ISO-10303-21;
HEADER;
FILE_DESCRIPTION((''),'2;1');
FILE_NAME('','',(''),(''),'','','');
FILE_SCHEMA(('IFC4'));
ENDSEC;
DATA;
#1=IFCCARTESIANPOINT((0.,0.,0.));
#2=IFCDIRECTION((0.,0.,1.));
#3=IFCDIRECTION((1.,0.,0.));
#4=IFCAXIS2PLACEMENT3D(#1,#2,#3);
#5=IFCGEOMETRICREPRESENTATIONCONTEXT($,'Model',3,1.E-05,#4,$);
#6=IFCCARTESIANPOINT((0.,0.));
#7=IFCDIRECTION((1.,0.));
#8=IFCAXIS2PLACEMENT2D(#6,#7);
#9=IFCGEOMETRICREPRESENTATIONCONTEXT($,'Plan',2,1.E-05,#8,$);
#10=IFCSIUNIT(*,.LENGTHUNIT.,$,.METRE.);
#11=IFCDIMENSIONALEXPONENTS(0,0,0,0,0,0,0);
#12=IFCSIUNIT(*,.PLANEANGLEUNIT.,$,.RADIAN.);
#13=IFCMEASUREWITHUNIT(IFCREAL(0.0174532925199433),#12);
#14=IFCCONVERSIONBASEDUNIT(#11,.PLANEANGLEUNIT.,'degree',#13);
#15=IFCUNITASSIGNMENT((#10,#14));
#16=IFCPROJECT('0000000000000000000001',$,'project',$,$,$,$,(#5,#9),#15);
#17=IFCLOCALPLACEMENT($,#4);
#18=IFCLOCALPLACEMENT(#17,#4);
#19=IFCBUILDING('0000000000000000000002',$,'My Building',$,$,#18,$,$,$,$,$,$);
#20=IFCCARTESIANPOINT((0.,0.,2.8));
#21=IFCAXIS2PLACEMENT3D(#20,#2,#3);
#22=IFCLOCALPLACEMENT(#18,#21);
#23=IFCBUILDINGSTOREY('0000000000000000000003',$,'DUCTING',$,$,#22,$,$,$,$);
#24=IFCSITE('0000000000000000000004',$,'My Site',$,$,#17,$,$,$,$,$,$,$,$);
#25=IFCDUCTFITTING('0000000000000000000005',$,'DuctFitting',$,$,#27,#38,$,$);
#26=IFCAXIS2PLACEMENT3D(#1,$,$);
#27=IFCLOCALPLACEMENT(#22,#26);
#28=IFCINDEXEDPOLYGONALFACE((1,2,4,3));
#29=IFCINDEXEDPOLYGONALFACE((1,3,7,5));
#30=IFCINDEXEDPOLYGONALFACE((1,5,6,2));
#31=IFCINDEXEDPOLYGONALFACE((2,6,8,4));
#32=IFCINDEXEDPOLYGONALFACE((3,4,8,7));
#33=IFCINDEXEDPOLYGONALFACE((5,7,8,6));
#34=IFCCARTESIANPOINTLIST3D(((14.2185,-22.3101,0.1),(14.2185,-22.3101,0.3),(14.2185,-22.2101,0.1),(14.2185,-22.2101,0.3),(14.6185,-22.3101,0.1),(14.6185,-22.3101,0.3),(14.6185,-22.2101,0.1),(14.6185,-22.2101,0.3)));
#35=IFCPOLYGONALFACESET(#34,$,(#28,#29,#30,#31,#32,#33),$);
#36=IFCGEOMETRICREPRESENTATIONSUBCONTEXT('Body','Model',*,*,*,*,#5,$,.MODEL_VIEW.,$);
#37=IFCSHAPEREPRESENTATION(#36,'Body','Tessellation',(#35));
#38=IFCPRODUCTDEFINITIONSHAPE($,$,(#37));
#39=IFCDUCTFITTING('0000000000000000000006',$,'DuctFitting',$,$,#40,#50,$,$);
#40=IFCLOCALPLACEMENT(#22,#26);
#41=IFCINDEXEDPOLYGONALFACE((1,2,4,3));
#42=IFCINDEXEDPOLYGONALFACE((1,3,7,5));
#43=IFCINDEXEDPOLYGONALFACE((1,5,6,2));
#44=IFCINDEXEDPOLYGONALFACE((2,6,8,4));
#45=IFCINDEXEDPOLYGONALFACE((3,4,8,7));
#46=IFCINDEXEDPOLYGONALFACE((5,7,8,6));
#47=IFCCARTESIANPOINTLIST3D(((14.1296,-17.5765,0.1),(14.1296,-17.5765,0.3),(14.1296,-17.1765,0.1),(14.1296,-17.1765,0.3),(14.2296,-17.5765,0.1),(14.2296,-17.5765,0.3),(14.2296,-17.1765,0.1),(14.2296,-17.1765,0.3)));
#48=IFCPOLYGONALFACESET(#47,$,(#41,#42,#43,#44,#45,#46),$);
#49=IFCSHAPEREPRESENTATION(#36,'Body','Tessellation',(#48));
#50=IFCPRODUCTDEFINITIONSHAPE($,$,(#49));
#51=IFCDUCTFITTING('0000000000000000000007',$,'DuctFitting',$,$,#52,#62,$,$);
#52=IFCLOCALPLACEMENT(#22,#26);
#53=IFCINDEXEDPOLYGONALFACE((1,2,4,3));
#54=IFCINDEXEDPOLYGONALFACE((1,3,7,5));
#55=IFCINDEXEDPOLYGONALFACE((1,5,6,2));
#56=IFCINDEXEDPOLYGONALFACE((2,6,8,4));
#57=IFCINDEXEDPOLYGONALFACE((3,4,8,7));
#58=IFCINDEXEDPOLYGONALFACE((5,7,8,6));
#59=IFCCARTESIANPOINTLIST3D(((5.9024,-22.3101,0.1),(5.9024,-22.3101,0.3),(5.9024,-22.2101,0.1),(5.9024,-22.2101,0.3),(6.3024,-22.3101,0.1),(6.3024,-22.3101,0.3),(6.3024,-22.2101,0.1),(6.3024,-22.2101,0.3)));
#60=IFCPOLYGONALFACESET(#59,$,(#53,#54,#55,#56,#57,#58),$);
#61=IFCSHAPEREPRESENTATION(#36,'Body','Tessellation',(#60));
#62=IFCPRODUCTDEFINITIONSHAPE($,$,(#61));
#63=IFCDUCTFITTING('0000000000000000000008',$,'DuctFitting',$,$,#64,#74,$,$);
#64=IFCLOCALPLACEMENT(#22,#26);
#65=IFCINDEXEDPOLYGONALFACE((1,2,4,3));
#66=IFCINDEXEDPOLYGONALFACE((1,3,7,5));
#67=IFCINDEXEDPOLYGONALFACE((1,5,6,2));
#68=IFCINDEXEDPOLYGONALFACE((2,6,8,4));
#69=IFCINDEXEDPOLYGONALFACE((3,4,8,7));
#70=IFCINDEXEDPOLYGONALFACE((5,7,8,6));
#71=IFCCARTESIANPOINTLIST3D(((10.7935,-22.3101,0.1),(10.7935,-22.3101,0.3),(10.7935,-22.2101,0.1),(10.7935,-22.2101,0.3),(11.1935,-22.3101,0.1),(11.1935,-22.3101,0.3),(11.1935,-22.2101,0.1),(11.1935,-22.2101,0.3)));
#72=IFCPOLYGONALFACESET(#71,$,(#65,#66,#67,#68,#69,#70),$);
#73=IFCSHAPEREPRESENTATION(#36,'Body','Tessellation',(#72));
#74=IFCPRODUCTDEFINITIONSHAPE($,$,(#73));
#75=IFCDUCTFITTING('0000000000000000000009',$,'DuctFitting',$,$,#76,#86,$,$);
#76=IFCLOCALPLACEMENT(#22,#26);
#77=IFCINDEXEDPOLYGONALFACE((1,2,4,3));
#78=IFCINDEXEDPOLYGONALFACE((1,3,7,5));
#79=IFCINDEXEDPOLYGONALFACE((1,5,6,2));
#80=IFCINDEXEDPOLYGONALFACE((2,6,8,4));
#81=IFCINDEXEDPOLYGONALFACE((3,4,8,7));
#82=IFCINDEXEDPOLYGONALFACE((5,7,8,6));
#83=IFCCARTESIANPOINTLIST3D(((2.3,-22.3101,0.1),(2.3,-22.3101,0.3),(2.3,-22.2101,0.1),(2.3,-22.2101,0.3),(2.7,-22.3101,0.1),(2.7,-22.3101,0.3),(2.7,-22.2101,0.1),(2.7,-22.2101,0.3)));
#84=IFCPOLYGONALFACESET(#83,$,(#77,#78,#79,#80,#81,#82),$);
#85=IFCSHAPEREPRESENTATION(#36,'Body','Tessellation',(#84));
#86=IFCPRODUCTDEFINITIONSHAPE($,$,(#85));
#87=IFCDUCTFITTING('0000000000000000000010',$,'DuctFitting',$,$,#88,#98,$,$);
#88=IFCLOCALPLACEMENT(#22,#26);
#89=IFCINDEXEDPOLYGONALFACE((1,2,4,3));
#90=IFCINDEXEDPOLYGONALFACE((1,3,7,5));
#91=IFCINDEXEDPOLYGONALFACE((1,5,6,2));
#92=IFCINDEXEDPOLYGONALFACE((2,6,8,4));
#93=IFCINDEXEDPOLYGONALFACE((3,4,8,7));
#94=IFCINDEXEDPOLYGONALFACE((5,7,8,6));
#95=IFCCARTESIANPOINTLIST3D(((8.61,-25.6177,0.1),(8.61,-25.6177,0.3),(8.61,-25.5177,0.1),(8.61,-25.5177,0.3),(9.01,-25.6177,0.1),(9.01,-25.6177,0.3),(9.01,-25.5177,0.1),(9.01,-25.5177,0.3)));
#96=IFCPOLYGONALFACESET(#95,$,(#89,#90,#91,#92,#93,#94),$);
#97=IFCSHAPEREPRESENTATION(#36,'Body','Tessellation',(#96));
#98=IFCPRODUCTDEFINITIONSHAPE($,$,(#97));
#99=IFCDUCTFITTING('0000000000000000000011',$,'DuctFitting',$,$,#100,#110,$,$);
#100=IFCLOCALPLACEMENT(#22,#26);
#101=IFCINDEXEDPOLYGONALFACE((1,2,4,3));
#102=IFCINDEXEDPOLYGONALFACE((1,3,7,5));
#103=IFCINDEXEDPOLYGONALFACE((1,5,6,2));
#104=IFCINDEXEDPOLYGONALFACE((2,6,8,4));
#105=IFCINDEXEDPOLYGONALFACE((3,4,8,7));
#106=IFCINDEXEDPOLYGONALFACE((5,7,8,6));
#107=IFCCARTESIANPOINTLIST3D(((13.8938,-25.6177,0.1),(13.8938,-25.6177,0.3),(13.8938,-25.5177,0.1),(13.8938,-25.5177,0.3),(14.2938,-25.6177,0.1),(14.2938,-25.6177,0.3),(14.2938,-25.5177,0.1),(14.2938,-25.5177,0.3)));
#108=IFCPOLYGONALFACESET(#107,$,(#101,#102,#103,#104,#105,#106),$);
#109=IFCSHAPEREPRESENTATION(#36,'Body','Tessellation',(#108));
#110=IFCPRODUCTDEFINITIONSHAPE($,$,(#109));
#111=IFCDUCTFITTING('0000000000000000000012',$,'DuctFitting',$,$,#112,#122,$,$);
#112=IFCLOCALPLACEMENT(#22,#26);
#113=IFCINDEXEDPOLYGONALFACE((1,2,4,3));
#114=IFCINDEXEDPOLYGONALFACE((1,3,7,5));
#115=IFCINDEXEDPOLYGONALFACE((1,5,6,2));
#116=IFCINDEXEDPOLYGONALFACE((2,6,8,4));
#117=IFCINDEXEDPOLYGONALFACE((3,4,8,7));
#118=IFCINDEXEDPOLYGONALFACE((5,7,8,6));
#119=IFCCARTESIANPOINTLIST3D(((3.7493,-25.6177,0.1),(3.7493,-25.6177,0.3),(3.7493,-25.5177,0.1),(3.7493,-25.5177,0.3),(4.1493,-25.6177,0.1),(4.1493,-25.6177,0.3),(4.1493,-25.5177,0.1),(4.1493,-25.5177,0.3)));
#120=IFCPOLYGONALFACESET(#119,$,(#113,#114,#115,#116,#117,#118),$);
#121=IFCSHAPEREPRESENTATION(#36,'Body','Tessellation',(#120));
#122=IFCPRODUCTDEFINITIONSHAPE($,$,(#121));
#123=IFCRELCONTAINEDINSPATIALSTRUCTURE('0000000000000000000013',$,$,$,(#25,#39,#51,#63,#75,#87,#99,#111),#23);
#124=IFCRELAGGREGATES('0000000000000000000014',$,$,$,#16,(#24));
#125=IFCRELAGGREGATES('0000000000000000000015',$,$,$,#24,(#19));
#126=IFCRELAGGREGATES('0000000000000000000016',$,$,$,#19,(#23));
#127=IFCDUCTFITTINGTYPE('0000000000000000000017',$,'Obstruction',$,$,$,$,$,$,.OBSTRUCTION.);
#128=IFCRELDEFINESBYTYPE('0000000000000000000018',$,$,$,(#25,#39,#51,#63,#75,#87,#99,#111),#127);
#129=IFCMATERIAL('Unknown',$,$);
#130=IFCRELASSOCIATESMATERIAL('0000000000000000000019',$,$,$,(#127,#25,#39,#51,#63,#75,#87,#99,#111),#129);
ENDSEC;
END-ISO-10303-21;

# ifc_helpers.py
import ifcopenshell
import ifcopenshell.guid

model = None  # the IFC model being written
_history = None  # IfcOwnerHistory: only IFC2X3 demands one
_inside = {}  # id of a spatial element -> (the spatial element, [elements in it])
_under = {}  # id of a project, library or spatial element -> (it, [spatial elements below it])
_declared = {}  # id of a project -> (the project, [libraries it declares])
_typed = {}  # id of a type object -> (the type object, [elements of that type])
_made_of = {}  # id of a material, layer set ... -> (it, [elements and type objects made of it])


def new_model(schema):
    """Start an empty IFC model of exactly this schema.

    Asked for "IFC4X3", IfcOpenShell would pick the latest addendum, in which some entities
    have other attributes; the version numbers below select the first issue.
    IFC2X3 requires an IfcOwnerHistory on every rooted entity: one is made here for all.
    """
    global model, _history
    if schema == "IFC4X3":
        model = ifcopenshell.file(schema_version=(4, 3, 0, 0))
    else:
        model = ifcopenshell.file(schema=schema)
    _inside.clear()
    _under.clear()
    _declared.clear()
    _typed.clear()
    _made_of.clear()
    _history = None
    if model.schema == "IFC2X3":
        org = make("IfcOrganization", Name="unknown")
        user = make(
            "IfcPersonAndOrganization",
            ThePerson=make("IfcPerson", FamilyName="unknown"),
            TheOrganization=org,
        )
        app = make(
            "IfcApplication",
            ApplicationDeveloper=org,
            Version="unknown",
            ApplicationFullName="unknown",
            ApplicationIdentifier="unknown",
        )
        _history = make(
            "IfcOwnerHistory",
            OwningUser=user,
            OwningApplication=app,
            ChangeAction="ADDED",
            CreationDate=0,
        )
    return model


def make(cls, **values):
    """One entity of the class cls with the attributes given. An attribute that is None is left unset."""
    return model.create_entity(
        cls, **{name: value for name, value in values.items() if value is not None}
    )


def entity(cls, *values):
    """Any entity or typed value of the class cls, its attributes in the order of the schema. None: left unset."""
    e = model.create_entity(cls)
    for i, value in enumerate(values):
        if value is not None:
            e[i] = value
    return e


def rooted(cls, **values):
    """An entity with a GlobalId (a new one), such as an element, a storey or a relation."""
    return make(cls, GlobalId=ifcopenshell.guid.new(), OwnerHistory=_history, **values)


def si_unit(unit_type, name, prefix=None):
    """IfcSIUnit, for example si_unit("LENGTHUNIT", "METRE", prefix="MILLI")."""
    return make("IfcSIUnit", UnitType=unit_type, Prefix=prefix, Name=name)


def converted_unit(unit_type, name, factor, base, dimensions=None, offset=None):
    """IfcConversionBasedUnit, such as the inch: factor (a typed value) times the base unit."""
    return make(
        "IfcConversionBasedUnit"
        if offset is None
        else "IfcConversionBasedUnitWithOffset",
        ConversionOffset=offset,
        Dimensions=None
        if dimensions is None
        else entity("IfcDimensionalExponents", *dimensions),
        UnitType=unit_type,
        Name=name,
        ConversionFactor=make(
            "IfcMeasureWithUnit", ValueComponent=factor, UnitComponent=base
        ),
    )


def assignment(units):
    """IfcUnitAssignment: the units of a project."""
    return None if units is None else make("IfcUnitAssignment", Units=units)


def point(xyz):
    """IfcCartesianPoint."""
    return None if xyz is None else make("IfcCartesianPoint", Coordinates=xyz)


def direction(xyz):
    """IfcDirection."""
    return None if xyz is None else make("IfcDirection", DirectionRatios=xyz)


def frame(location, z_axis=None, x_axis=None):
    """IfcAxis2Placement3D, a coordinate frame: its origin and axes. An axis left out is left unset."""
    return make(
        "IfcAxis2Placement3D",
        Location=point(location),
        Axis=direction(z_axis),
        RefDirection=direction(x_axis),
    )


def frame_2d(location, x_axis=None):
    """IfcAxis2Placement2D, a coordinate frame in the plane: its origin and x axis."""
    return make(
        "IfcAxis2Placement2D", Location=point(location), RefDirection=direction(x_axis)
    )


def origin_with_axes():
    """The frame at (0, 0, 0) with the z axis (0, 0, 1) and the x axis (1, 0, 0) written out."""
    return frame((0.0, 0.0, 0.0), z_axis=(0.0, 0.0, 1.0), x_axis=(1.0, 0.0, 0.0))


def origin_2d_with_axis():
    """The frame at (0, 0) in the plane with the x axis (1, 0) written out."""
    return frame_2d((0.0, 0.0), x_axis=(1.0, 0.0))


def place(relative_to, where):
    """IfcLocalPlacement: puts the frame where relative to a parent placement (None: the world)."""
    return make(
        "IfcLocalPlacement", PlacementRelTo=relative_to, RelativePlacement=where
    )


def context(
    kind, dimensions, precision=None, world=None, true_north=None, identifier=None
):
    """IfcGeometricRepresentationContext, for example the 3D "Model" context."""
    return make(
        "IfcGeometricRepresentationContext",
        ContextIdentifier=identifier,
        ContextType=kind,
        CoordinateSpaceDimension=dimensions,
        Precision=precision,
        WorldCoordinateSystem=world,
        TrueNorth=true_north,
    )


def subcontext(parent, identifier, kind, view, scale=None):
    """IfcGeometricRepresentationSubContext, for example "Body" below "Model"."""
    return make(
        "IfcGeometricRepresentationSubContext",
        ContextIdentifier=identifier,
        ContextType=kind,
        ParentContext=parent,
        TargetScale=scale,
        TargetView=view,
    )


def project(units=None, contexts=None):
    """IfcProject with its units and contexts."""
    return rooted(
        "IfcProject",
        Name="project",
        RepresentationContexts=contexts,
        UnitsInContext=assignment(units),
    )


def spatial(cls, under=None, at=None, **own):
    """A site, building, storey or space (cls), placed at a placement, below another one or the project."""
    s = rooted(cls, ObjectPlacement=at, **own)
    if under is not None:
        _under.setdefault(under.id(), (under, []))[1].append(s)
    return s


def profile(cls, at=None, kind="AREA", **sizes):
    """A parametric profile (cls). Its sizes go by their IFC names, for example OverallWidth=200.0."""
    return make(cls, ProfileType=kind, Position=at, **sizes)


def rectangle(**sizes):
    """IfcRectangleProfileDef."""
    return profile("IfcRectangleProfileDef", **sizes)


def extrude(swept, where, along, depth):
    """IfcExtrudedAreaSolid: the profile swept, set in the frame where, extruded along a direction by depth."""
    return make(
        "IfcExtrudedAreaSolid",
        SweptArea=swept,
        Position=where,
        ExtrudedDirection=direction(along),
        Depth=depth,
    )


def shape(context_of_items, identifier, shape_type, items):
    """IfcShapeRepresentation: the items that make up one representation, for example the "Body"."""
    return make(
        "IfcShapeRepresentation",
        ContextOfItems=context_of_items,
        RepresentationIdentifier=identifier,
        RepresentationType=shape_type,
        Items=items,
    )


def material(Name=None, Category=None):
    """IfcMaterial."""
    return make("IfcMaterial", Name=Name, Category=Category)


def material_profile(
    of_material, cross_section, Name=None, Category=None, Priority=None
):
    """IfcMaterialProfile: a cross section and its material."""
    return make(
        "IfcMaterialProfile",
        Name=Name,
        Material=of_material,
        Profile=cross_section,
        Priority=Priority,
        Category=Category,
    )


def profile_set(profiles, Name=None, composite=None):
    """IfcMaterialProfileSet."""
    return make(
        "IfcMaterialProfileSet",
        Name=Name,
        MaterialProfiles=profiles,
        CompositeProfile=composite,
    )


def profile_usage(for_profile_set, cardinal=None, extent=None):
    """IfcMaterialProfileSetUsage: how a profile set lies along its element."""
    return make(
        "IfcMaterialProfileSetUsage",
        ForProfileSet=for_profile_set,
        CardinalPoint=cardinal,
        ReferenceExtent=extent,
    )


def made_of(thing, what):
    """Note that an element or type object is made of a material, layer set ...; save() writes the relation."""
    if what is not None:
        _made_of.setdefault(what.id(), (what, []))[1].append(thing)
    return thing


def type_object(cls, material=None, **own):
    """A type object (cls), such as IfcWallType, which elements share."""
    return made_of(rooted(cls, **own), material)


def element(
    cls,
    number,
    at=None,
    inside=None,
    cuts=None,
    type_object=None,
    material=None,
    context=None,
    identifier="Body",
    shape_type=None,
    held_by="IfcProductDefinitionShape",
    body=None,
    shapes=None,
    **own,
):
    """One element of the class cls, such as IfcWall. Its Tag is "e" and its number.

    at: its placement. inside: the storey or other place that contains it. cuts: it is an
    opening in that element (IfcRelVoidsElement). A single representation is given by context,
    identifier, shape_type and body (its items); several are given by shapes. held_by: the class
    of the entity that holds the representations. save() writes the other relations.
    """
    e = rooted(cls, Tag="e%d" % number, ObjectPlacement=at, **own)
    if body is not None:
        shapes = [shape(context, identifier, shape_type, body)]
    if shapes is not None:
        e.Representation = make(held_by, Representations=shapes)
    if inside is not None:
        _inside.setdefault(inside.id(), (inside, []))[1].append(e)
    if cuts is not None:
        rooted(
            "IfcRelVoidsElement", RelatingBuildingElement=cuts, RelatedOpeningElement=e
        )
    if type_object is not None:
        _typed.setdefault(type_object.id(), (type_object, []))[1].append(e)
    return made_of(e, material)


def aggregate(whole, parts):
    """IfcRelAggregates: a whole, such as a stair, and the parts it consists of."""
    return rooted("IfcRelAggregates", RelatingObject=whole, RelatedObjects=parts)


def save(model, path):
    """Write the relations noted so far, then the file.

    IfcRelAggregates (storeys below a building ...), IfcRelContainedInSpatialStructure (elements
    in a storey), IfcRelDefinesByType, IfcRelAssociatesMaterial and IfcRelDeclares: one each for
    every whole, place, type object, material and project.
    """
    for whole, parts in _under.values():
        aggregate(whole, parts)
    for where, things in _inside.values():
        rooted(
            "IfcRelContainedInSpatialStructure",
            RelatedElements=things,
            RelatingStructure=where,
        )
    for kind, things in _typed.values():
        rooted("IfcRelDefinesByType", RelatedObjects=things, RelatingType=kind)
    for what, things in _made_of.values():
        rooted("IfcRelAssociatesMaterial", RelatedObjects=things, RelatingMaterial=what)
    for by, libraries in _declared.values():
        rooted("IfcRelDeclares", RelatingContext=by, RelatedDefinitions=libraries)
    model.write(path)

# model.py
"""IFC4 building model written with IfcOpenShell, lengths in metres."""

from ifc_helpers import new_model, entity, si_unit, converted_unit, frame, origin_with_axes, origin_2d_with_axis, place, context, subcontext, project, spatial, rectangle, extrude, material, material_profile, profile_set, profile_usage, type_object, element, save


model = new_model("IFC4")

# Units and contexts
model_context = context("Model", 3, precision=1e-05, world=origin_with_axes())
plan_context = context("Plan", 2, precision=1e-05, world=origin_2d_with_axis())
body_context = subcontext(model_context, "Body", "Model", "MODEL_VIEW")
ifc_project = project(units=[si_unit("LENGTHUNIT", "METRE"), converted_unit("PLANEANGLEUNIT", "degree", entity("IfcReal", 0.0174532925199433), si_unit("PLANEANGLEUNIT", "RADIAN"), dimensions=[0, 0, 0, 0, 0, 0, 0])], contexts=[model_context, plan_context])

# Site, building, storey
site_placement = place(None, origin_with_axes())
site = spatial("IfcSite", under=ifc_project, at=site_placement, Name="My Site")
building_placement = place(site_placement, origin_with_axes())
building = spatial("IfcBuilding", under=site, at=building_placement, Name="My Building")
storey_placement = place(building_placement, frame((0.0, 0.0, 2.8), z_axis=(0.0, 0.0, 1.0), x_axis=(1.0, 0.0, 0.0)))
storey = spatial("IfcBuildingStorey", under=building, at=storey_placement, Name="DUCTING")

# Shared definitions
ifc_material = material(Name="Unknown")

# Duct fittings
ifc_material_profile_1 = material_profile(ifc_material, rectangle(XDim=0.4, YDim=0.2))
ifc_profile_set_1 = profile_set([ifc_material_profile_1])
ifc_profile_usage_1 = profile_usage(ifc_profile_set_1, cardinal=5)
duct_fitting_type_1 = type_object("IfcDuctFittingType", Name="Obstruction", PredefinedType="OBSTRUCTION", material=ifc_profile_set_1)
duct_fitting_1_placement = place(storey_placement, frame((14.4185, -22.3101, 0.2), z_axis=(0.0, 1.0, 0.0), x_axis=(-1.0, 0.0, 0.0)))
element("IfcDuctFitting", 1, at=duct_fitting_1_placement, inside=storey, type_object=duct_fitting_type_1, material=ifc_profile_usage_1, Name="DuctFitting", context=body_context, shape_type="SweptSolid", body=[
    extrude(rectangle(XDim=0.4, YDim=0.2), origin_with_axes(), (0.0, 0.0, 1.0), 0.1),
])
ifc_profile_usage_2 = profile_usage(ifc_profile_set_1, cardinal=5)
duct_fitting_2_placement = place(storey_placement, frame((14.2296, -17.3765, 0.2), z_axis=(-1.0, 0.0, 0.0), x_axis=(0.0, -1.0, 0.0)))
element("IfcDuctFitting", 2, at=duct_fitting_2_placement, inside=storey, type_object=duct_fitting_type_1, material=ifc_profile_usage_2, Name="DuctFitting", context=body_context, shape_type="SweptSolid", body=[
    extrude(rectangle(XDim=0.4, YDim=0.2), origin_with_axes(), (0.0, 0.0, 1.0), 0.1),
])
ifc_profile_usage_3 = profile_usage(ifc_profile_set_1, cardinal=5)
duct_fitting_3_placement = place(storey_placement, frame((6.1024, -22.3101, 0.2), z_axis=(0.0, 1.0, 0.0), x_axis=(-1.0, 0.0, 0.0)))
element("IfcDuctFitting", 3, at=duct_fitting_3_placement, inside=storey, type_object=duct_fitting_type_1, material=ifc_profile_usage_3, Name="DuctFitting", context=body_context, shape_type="SweptSolid", body=[
    extrude(rectangle(XDim=0.4, YDim=0.2), origin_with_axes(), (0.0, 0.0, 1.0), 0.1),
])
ifc_profile_usage_4 = profile_usage(ifc_profile_set_1, cardinal=5)
duct_fitting_4_placement = place(storey_placement, frame((10.9935, -22.3101, 0.2), z_axis=(0.0, 1.0, 0.0), x_axis=(-1.0, 0.0, 0.0)))
element("IfcDuctFitting", 4, at=duct_fitting_4_placement, inside=storey, type_object=duct_fitting_type_1, material=ifc_profile_usage_4, Name="DuctFitting", context=body_context, shape_type="SweptSolid", body=[
    extrude(rectangle(XDim=0.4, YDim=0.2), origin_with_axes(), (0.0, 0.0, 1.0), 0.1),
])
ifc_profile_usage_5 = profile_usage(ifc_profile_set_1, cardinal=5)
duct_fitting_5_placement = place(storey_placement, frame((2.5, -22.2101, 0.2), z_axis=(0.0, -1.0, 0.0), x_axis=(1.0, 0.0, 0.0)))
element("IfcDuctFitting", 5, at=duct_fitting_5_placement, inside=storey, type_object=duct_fitting_type_1, material=ifc_profile_usage_5, Name="DuctFitting", context=body_context, shape_type="SweptSolid", body=[
    extrude(rectangle(XDim=0.4, YDim=0.2), origin_with_axes(), (0.0, 0.0, 1.0), 0.1),
])
ifc_profile_usage_6 = profile_usage(ifc_profile_set_1, cardinal=5)
duct_fitting_6_placement = place(storey_placement, frame((8.81, -25.5177, 0.2), z_axis=(0.0, -1.0, 0.0), x_axis=(1.0, 0.0, 0.0)))
element("IfcDuctFitting", 6, at=duct_fitting_6_placement, inside=storey, type_object=duct_fitting_type_1, material=ifc_profile_usage_6, Name="DuctFitting", context=body_context, shape_type="SweptSolid", body=[
    extrude(rectangle(XDim=0.4, YDim=0.2), origin_with_axes(), (0.0, 0.0, 1.0), 0.1),
])
ifc_profile_usage_7 = profile_usage(ifc_profile_set_1, cardinal=5)
duct_fitting_7_placement = place(storey_placement, frame((14.0938, -25.5177, 0.2), z_axis=(0.0, -1.0, 0.0), x_axis=(1.0, 0.0, 0.0)))
element("IfcDuctFitting", 7, at=duct_fitting_7_placement, inside=storey, type_object=duct_fitting_type_1, material=ifc_profile_usage_7, Name="DuctFitting", context=body_context, shape_type="SweptSolid", body=[
    extrude(rectangle(XDim=0.4, YDim=0.2), origin_with_axes(), (0.0, 0.0, 1.0), 0.1),
])
ifc_profile_usage_8 = profile_usage(ifc_profile_set_1, cardinal=5)
duct_fitting_8_placement = place(storey_placement, frame((3.9493, -25.5177, 0.2), z_axis=(0.0, -1.0, 0.0), x_axis=(1.0, 0.0, 0.0)))
element("IfcDuctFitting", 8, at=duct_fitting_8_placement, inside=storey, type_object=duct_fitting_type_1, material=ifc_profile_usage_8, Name="DuctFitting", context=body_context, shape_type="SweptSolid", body=[
    extrude(rectangle(XDim=0.4, YDim=0.2), origin_with_axes(), (0.0, 0.0, 1.0), 0.1),
])

save(model, "model.ifc")
